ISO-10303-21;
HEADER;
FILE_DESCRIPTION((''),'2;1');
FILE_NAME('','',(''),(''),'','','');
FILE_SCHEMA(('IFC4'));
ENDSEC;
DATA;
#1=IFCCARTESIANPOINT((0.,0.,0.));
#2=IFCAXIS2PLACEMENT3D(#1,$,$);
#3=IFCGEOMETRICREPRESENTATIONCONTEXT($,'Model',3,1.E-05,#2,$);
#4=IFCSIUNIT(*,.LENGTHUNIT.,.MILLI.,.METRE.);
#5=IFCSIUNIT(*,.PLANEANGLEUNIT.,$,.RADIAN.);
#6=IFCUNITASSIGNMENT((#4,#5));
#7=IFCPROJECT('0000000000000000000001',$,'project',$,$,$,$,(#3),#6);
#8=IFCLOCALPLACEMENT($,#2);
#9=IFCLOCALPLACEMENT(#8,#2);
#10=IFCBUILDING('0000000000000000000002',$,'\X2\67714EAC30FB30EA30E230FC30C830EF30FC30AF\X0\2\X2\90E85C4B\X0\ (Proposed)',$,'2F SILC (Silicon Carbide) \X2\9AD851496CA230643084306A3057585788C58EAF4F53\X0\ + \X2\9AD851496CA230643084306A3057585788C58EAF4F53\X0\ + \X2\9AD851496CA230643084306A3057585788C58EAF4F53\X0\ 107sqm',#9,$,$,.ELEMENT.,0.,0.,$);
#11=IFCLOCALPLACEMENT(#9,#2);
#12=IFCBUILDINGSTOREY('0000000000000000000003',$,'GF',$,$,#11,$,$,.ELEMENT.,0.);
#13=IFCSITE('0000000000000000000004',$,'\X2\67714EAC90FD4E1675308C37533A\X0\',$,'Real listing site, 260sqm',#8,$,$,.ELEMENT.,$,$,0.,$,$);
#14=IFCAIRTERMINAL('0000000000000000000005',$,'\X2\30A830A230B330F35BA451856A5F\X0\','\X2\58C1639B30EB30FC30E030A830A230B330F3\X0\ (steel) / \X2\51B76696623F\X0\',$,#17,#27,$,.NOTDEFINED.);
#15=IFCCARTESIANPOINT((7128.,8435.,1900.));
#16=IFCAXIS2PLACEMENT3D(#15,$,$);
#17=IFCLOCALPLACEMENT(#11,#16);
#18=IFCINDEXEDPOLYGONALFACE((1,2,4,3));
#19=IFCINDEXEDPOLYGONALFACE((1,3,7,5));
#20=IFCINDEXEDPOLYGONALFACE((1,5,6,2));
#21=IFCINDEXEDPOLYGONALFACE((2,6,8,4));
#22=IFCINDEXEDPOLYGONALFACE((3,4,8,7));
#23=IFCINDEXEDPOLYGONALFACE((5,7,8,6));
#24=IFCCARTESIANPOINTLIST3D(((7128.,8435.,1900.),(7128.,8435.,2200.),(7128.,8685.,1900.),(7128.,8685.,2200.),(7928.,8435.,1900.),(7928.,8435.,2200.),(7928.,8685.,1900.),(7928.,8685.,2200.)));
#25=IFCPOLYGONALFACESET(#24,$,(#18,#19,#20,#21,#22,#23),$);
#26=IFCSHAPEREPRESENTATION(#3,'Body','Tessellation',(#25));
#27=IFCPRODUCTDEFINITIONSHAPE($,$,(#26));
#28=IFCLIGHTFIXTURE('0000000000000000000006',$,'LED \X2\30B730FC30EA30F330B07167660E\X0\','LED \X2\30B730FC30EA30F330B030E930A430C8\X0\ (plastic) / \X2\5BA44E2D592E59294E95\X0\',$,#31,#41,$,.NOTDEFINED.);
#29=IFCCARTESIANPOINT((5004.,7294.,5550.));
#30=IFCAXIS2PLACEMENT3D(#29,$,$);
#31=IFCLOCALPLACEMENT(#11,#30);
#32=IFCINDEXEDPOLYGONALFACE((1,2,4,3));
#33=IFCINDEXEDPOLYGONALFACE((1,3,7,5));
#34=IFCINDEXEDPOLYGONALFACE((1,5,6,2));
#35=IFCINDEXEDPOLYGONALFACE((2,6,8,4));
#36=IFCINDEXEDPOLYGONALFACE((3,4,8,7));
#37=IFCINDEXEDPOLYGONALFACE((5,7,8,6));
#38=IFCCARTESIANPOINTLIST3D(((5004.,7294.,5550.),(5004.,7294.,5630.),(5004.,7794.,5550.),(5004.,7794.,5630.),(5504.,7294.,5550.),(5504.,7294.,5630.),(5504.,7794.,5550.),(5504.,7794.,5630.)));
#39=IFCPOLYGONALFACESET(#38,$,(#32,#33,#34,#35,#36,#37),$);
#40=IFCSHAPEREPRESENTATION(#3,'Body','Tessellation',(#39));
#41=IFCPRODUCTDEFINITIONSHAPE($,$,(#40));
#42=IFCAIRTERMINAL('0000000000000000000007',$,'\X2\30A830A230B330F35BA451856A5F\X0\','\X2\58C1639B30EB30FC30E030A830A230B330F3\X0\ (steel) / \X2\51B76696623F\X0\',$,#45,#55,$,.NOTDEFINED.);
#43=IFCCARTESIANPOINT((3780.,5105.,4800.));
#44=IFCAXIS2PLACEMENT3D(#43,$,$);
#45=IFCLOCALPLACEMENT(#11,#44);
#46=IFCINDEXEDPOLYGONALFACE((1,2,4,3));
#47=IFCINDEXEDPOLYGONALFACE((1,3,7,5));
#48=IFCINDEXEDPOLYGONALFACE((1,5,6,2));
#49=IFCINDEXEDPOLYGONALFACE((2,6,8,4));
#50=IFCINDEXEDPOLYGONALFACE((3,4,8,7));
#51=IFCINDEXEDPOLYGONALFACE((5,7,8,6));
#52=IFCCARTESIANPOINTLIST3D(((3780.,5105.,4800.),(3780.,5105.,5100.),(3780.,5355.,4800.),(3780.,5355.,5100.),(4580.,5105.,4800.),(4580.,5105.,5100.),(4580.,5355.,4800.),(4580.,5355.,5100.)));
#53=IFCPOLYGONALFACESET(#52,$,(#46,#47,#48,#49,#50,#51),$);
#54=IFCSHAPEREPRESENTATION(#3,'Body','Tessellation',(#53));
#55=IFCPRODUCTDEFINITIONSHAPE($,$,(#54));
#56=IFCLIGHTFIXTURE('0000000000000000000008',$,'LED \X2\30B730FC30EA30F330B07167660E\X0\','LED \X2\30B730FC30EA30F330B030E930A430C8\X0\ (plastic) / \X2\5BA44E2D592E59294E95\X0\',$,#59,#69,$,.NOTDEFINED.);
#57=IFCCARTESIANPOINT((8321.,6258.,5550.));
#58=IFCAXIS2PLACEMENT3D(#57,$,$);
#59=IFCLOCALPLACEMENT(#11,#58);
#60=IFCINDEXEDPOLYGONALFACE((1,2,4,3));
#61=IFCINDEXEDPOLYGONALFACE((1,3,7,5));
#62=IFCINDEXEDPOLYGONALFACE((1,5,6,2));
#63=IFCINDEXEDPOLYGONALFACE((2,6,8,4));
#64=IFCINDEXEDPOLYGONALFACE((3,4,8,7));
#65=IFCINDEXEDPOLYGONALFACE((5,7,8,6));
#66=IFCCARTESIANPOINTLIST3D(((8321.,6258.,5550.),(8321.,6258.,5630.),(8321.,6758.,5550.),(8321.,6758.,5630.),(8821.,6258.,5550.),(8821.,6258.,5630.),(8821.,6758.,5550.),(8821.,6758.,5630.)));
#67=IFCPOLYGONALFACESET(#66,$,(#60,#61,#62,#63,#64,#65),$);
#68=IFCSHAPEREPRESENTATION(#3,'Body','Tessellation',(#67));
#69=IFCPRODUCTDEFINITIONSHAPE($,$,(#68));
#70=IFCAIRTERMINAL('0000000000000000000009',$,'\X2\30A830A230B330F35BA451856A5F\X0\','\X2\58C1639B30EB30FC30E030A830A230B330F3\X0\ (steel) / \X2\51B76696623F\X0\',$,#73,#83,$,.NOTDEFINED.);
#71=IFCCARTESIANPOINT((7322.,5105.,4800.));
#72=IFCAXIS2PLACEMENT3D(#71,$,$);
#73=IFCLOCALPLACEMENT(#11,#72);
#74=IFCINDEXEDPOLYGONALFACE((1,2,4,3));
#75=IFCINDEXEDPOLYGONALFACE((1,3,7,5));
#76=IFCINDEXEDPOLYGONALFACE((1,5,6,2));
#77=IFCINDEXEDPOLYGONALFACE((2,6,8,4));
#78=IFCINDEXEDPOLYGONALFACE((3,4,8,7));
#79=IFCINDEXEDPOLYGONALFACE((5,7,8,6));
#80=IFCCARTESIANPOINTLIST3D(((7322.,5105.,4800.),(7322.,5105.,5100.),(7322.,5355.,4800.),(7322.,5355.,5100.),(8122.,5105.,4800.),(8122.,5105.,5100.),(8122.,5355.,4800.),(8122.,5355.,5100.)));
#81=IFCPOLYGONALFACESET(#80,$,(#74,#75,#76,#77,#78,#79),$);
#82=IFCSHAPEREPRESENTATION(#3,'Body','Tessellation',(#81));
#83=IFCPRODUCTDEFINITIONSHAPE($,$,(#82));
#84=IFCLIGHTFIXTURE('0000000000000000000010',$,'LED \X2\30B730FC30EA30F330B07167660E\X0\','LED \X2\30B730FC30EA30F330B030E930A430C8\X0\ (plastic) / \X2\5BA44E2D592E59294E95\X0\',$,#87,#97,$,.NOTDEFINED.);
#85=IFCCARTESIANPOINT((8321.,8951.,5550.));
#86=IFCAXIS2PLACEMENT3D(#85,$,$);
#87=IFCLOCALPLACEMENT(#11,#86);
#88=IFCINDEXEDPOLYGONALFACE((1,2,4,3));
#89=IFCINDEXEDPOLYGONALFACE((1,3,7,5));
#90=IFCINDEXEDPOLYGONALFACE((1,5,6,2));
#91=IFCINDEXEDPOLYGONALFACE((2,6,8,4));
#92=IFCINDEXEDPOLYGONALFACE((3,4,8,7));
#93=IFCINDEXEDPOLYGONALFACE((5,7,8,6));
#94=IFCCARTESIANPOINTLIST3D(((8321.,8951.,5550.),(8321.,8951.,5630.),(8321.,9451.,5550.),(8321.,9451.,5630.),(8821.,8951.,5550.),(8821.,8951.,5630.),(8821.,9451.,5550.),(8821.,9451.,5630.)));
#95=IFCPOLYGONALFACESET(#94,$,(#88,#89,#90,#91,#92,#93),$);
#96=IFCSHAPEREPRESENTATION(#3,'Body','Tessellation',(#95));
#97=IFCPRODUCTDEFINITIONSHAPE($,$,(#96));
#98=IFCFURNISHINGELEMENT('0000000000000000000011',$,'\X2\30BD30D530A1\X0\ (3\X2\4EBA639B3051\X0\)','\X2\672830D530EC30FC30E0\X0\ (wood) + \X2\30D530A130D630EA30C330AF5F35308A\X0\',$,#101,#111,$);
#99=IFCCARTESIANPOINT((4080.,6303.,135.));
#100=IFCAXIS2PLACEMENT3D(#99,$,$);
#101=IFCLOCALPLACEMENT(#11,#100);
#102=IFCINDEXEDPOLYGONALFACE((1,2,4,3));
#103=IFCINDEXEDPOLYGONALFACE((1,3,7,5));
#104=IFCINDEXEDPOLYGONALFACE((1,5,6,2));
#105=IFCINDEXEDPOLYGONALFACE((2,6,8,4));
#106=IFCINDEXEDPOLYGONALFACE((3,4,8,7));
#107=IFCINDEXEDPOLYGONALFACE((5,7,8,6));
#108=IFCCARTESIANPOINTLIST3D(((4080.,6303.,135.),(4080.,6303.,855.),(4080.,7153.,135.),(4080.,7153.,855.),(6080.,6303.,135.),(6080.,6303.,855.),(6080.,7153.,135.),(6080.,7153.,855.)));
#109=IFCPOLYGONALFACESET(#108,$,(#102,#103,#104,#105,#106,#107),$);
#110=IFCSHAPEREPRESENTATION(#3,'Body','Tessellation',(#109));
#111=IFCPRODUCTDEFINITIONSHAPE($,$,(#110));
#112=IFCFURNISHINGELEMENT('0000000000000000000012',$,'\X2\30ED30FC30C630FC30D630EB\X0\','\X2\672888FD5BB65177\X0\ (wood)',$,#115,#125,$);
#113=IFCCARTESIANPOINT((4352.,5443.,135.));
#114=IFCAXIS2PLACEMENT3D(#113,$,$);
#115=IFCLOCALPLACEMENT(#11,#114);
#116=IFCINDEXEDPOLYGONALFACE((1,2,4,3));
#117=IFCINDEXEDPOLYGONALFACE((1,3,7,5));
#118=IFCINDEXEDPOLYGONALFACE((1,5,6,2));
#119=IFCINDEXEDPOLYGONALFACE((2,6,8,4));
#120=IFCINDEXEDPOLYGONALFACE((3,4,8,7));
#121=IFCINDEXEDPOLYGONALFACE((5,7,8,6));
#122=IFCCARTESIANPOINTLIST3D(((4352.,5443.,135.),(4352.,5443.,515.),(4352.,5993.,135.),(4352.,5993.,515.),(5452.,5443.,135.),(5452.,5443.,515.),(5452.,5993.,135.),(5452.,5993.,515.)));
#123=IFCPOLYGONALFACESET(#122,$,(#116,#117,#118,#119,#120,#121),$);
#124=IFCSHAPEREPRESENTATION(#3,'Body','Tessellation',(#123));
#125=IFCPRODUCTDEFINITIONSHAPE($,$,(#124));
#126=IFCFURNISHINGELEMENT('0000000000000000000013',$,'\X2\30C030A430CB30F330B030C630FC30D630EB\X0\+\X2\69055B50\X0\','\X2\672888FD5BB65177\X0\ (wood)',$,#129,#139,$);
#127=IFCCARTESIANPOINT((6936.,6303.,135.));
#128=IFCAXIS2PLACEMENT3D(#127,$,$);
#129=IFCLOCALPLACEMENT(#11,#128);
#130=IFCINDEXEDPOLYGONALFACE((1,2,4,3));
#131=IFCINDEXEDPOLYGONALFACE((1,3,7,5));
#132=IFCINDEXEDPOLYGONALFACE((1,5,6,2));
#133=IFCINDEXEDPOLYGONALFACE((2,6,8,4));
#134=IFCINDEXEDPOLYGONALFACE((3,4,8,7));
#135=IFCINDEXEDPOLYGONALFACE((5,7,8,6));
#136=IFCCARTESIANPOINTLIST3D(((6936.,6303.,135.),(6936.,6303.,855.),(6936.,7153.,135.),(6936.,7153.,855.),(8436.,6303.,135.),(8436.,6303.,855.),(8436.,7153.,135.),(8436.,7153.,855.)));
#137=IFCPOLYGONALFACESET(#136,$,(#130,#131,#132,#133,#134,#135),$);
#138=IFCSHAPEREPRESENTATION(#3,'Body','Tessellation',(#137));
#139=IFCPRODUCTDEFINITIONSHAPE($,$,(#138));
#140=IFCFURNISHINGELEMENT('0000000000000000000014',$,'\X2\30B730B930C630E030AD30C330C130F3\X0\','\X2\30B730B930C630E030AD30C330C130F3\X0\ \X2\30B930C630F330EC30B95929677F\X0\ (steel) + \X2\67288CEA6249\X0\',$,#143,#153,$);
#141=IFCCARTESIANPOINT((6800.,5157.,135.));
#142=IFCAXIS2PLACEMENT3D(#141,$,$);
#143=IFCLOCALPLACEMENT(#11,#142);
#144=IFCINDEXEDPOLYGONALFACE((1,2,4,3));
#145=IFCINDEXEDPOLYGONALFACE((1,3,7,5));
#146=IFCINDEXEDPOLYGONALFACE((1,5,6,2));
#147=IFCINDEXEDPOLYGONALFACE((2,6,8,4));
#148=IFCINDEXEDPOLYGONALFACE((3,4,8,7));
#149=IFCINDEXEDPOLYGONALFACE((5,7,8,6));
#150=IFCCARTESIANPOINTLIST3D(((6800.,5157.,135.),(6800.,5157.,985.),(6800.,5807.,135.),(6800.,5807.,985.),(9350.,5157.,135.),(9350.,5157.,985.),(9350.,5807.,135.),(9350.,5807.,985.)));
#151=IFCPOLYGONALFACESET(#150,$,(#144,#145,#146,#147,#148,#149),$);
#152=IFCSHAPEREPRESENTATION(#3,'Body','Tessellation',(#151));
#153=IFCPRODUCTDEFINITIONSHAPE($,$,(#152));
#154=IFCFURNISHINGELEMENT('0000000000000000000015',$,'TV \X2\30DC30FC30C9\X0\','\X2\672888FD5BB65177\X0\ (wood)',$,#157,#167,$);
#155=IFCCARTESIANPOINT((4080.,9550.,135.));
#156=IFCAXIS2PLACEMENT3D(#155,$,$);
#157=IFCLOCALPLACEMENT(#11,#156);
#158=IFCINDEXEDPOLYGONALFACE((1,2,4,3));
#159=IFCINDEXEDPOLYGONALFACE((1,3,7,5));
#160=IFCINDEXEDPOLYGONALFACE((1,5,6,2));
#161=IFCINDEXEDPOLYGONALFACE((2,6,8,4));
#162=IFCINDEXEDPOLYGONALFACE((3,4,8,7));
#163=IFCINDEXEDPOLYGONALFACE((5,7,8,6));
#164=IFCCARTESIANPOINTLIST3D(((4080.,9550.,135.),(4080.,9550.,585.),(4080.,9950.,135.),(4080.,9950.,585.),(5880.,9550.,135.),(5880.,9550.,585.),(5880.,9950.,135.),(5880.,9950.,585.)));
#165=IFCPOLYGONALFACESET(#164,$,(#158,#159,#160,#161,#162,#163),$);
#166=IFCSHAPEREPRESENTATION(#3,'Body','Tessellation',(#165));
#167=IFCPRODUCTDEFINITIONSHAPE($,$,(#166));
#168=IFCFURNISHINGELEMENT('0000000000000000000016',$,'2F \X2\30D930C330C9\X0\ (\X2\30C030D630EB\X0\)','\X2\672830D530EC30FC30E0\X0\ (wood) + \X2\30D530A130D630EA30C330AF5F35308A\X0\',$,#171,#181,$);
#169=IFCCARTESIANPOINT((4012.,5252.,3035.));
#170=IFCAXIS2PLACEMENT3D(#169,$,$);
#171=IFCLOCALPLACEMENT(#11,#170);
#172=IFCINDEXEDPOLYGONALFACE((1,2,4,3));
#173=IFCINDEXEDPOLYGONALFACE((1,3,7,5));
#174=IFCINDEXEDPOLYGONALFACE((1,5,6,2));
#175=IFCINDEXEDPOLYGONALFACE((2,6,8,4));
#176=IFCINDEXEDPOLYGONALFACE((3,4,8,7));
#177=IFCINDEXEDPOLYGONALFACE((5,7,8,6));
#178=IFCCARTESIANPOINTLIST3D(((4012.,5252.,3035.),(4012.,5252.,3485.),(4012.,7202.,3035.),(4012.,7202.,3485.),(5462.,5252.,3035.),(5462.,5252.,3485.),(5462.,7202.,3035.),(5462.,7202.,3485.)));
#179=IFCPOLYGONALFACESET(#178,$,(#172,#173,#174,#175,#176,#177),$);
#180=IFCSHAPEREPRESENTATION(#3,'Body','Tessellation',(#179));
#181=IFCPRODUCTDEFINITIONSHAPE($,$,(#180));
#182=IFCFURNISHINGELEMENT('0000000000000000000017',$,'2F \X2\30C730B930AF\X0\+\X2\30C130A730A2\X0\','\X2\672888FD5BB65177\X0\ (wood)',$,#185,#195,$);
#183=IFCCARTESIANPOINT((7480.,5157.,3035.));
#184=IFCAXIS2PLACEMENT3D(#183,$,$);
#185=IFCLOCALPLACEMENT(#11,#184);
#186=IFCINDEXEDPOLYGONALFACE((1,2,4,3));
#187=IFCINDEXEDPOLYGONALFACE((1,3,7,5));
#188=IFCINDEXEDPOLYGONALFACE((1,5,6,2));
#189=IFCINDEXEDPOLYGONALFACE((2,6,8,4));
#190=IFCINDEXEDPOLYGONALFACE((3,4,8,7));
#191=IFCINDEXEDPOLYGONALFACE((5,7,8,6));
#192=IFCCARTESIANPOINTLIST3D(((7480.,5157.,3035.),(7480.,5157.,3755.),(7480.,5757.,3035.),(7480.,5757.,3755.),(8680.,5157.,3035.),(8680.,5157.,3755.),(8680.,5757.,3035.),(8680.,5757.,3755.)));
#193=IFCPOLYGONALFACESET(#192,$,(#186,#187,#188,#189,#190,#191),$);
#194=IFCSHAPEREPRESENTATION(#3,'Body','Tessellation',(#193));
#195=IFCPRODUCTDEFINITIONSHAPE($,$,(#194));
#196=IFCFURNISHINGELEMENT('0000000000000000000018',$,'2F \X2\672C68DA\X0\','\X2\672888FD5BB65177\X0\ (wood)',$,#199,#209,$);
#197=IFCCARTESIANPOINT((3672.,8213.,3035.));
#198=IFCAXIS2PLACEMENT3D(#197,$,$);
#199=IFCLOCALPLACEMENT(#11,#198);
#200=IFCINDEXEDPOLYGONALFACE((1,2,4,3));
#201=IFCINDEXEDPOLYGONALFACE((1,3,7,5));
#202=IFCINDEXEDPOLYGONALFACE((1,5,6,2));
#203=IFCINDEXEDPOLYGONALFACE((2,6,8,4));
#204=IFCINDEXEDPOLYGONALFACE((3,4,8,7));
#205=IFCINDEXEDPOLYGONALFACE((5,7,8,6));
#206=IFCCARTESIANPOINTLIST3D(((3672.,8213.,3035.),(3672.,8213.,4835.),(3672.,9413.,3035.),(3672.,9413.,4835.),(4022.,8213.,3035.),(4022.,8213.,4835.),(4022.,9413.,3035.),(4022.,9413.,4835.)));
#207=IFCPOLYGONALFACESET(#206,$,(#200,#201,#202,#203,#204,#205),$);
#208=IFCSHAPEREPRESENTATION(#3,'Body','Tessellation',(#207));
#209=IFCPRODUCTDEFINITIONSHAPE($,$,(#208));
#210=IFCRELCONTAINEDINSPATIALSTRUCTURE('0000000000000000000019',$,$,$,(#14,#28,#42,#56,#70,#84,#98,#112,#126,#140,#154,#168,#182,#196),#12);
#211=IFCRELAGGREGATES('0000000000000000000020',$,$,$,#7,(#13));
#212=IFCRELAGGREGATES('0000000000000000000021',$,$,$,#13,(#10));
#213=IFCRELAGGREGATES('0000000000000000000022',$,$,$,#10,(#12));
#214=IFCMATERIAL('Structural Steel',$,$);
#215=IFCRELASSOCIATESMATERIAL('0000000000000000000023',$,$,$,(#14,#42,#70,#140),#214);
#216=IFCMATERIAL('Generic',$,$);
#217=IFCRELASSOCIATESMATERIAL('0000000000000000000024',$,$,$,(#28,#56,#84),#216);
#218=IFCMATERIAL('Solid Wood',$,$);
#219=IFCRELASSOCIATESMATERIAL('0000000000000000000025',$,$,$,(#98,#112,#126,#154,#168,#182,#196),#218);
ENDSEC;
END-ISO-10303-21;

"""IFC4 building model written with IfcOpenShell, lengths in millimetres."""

from ifc_helpers import new_model, si_unit, frame, frame_2d, origin, place, context, project, spatial, rectangle, extrude, material, element, save


model = new_model("IFC4")

# Units and contexts
model_context = context("Model", 3, precision=1e-05, world=origin())
ifc_project = project(units=[si_unit("LENGTHUNIT", "METRE", prefix="MILLI"), si_unit("PLANEANGLEUNIT", "RADIAN")], contexts=[model_context])

# Site, building, storey
site_placement = place(None, origin())
site = spatial("IfcSite", under=ifc_project, at=site_placement, Name="東京都世田谷区", ObjectType="Real listing site, 260sqm", CompositionType="ELEMENT", RefElevation=0.0)
building_placement = place(site_placement, origin())
building = spatial("IfcBuilding", under=site, at=building_placement, Name="東京・リモートワーク2部屋 (Proposed)", ObjectType="2F SILC (Silicon Carbide) 高光沢つやなし塗装躯体 + 高光沢つやなし塗装躯体 + 高光沢つやなし塗装躯体 107sqm", CompositionType="ELEMENT", ElevationOfRefHeight=0.0, ElevationOfTerrain=0.0)
storey_placement = place(building_placement, origin())
storey = spatial("IfcBuildingStorey", under=building, at=storey_placement, Name="GF", CompositionType="ELEMENT", Elevation=0.0)

# Shared definitions
ifc_material_1 = material(Name="Solid Wood")

# Shared definitions
ifc_material_2 = material(Name="Structural Steel")

# Shared definitions
ifc_material_3 = material(Name="Generic")

# Air terminal
air_terminal_1_placement = place(storey_placement, frame((7128.0, 8435.0, 1900.0)))
element("IfcAirTerminal", 1, at=air_terminal_1_placement, inside=storey, material=ifc_material_2, Name="エアコン室内機", Description="壁掛ルームエアコン (steel) / 冷暖房", PredefinedType="NOTDEFINED", context=model_context, shape_type="SweptSolid", body=[
    extrude(rectangle(XDim=800.0, YDim=250.0, at=frame_2d((400.0, 125.0))), frame((7128.0, 8435.0, 1900.0)), (0.0, 0.0, 1.0), 300.0),
])

# Light fixture
light_fixture_1_placement = place(storey_placement, frame((5004.0, 7294.0, 5550.0)))
element("IfcLightFixture", 2, at=light_fixture_1_placement, inside=storey, material=ifc_material_3, Name="LED シーリング照明", Description="LED シーリングライト (plastic) / 室中央天井", PredefinedType="NOTDEFINED", context=model_context, shape_type="SweptSolid", body=[
    extrude(rectangle(XDim=500.0, YDim=500.0, at=frame_2d((250.0, 250.0))), frame((5004.0, 7294.0, 5550.0)), (0.0, 0.0, 1.0), 80.0),
])

# Air terminal
air_terminal_2_placement = place(storey_placement, frame((3780.0, 5105.0, 4800.0)))
element("IfcAirTerminal", 3, at=air_terminal_2_placement, inside=storey, material=ifc_material_2, Name="エアコン室内機", Description="壁掛ルームエアコン (steel) / 冷暖房", PredefinedType="NOTDEFINED", context=model_context, shape_type="SweptSolid", body=[
    extrude(rectangle(XDim=800.0, YDim=250.0, at=frame_2d((400.0, 125.0))), frame((3780.0, 5105.0, 4800.0)), (0.0, 0.0, 1.0), 300.0),
])

# Light fixture
light_fixture_2_placement = place(storey_placement, frame((8321.0, 6258.0, 5550.0)))
element("IfcLightFixture", 4, at=light_fixture_2_placement, inside=storey, material=ifc_material_3, Name="LED シーリング照明", Description="LED シーリングライト (plastic) / 室中央天井", PredefinedType="NOTDEFINED", context=model_context, shape_type="SweptSolid", body=[
    extrude(rectangle(XDim=500.0, YDim=500.0, at=frame_2d((250.0, 250.0))), frame((8321.0, 6258.0, 5550.0)), (0.0, 0.0, 1.0), 80.0),
])

# Air terminal
air_terminal_3_placement = place(storey_placement, frame((7322.0, 5105.0, 4800.0)))
element("IfcAirTerminal", 5, at=air_terminal_3_placement, inside=storey, material=ifc_material_2, Name="エアコン室内機", Description="壁掛ルームエアコン (steel) / 冷暖房", PredefinedType="NOTDEFINED", context=model_context, shape_type="SweptSolid", body=[
    extrude(rectangle(XDim=800.0, YDim=250.0, at=frame_2d((400.0, 125.0))), frame((7322.0, 5105.0, 4800.0)), (0.0, 0.0, 1.0), 300.0),
])

# Light fixture
light_fixture_3_placement = place(storey_placement, frame((8321.0, 8951.0, 5550.0)))
element("IfcLightFixture", 6, at=light_fixture_3_placement, inside=storey, material=ifc_material_3, Name="LED シーリング照明", Description="LED シーリングライト (plastic) / 室中央天井", PredefinedType="NOTDEFINED", context=model_context, shape_type="SweptSolid", body=[
    extrude(rectangle(XDim=500.0, YDim=500.0, at=frame_2d((250.0, 250.0))), frame((8321.0, 8951.0, 5550.0)), (0.0, 0.0, 1.0), 80.0),
])

# Furnishing elements
furnishing_1_placement = place(storey_placement, frame((4080.0, 6303.0, 135.0)))
element("IfcFurnishingElement", 7, at=furnishing_1_placement, inside=storey, material=ifc_material_1, Name="ソファ (3人掛け)", Description="木フレーム (wood) + ファブリック張り", context=model_context, shape_type="SweptSolid", body=[
    extrude(rectangle(XDim=2000.0, YDim=850.0, at=frame_2d((1000.0, 425.0))), frame((4080.0, 6303.0, 135.0)), (0.0, 0.0, 1.0), 720.0),
])
furnishing_2_placement = place(storey_placement, frame((4352.0, 5443.0, 135.0)))
element("IfcFurnishingElement", 8, at=furnishing_2_placement, inside=storey, material=ifc_material_1, Name="ローテーブル", Description="木製家具 (wood)", context=model_context, shape_type="SweptSolid", body=[
    extrude(rectangle(XDim=1100.0, YDim=550.0, at=frame_2d((550.0, 275.0))), frame((4352.0, 5443.0, 135.0)), (0.0, 0.0, 1.0), 380.0),
])
furnishing_3_placement = place(storey_placement, frame((6936.0, 6303.0, 135.0)))
element("IfcFurnishingElement", 9, at=furnishing_3_placement, inside=storey, material=ifc_material_1, Name="ダイニングテーブル+椅子", Description="木製家具 (wood)", context=model_context, shape_type="SweptSolid", body=[
    extrude(rectangle(XDim=1500.0, YDim=850.0, at=frame_2d((750.0, 425.0))), frame((6936.0, 6303.0, 135.0)), (0.0, 0.0, 1.0), 720.0),
])
furnishing_4_placement = place(storey_placement, frame((6800.0, 5157.0, 135.0)))
element("IfcFurnishingElement", 10, at=furnishing_4_placement, inside=storey, material=ifc_material_2, Name="システムキッチン", Description="システムキッチン ステンレス天板 (steel) + 木質扉", context=model_context, shape_type="SweptSolid", body=[
    extrude(rectangle(XDim=2550.0, YDim=650.0, at=frame_2d((1275.0, 325.0))), frame((6800.0, 5157.0, 135.0)), (0.0, 0.0, 1.0), 850.0),
])
furnishing_5_placement = place(storey_placement, frame((4080.0, 9550.0, 135.0)))
element("IfcFurnishingElement", 11, at=furnishing_5_placement, inside=storey, material=ifc_material_1, Name="TV ボード", Description="木製家具 (wood)", context=model_context, shape_type="SweptSolid", body=[
    extrude(rectangle(XDim=1800.0, YDim=400.0, at=frame_2d((900.0, 200.0))), frame((4080.0, 9550.0, 135.0)), (0.0, 0.0, 1.0), 450.0),
])
furnishing_6_placement = place(storey_placement, frame((4012.0, 5252.0, 3035.0)))
element("IfcFurnishingElement", 12, at=furnishing_6_placement, inside=storey, material=ifc_material_1, Name="2F ベッド (ダブル)", Description="木フレーム (wood) + ファブリック張り", context=model_context, shape_type="SweptSolid", body=[
    extrude(rectangle(XDim=1450.0, YDim=1950.0, at=frame_2d((725.0, 975.0))), frame((4012.0, 5252.0, 3035.0)), (0.0, 0.0, 1.0), 450.0),
])
furnishing_7_placement = place(storey_placement, frame((7480.0, 5157.0, 3035.0)))
element("IfcFurnishingElement", 13, at=furnishing_7_placement, inside=storey, material=ifc_material_1, Name="2F デスク+チェア", Description="木製家具 (wood)", context=model_context, shape_type="SweptSolid", body=[
    extrude(rectangle(XDim=1200.0, YDim=600.0, at=frame_2d((600.0, 300.0))), frame((7480.0, 5157.0, 3035.0)), (0.0, 0.0, 1.0), 720.0),
])
furnishing_8_placement = place(storey_placement, frame((3672.0, 8213.0, 3035.0)))
element("IfcFurnishingElement", 14, at=furnishing_8_placement, inside=storey, material=ifc_material_1, Name="2F 本棚", Description="木製家具 (wood)", context=model_context, shape_type="SweptSolid", body=[
    extrude(rectangle(XDim=350.0, YDim=1200.0, at=frame_2d((175.0, 600.0))), frame((3672.0, 8213.0, 3035.0)), (0.0, 0.0, 1.0), 1800.0),
])

save(model, "model.ifc")
